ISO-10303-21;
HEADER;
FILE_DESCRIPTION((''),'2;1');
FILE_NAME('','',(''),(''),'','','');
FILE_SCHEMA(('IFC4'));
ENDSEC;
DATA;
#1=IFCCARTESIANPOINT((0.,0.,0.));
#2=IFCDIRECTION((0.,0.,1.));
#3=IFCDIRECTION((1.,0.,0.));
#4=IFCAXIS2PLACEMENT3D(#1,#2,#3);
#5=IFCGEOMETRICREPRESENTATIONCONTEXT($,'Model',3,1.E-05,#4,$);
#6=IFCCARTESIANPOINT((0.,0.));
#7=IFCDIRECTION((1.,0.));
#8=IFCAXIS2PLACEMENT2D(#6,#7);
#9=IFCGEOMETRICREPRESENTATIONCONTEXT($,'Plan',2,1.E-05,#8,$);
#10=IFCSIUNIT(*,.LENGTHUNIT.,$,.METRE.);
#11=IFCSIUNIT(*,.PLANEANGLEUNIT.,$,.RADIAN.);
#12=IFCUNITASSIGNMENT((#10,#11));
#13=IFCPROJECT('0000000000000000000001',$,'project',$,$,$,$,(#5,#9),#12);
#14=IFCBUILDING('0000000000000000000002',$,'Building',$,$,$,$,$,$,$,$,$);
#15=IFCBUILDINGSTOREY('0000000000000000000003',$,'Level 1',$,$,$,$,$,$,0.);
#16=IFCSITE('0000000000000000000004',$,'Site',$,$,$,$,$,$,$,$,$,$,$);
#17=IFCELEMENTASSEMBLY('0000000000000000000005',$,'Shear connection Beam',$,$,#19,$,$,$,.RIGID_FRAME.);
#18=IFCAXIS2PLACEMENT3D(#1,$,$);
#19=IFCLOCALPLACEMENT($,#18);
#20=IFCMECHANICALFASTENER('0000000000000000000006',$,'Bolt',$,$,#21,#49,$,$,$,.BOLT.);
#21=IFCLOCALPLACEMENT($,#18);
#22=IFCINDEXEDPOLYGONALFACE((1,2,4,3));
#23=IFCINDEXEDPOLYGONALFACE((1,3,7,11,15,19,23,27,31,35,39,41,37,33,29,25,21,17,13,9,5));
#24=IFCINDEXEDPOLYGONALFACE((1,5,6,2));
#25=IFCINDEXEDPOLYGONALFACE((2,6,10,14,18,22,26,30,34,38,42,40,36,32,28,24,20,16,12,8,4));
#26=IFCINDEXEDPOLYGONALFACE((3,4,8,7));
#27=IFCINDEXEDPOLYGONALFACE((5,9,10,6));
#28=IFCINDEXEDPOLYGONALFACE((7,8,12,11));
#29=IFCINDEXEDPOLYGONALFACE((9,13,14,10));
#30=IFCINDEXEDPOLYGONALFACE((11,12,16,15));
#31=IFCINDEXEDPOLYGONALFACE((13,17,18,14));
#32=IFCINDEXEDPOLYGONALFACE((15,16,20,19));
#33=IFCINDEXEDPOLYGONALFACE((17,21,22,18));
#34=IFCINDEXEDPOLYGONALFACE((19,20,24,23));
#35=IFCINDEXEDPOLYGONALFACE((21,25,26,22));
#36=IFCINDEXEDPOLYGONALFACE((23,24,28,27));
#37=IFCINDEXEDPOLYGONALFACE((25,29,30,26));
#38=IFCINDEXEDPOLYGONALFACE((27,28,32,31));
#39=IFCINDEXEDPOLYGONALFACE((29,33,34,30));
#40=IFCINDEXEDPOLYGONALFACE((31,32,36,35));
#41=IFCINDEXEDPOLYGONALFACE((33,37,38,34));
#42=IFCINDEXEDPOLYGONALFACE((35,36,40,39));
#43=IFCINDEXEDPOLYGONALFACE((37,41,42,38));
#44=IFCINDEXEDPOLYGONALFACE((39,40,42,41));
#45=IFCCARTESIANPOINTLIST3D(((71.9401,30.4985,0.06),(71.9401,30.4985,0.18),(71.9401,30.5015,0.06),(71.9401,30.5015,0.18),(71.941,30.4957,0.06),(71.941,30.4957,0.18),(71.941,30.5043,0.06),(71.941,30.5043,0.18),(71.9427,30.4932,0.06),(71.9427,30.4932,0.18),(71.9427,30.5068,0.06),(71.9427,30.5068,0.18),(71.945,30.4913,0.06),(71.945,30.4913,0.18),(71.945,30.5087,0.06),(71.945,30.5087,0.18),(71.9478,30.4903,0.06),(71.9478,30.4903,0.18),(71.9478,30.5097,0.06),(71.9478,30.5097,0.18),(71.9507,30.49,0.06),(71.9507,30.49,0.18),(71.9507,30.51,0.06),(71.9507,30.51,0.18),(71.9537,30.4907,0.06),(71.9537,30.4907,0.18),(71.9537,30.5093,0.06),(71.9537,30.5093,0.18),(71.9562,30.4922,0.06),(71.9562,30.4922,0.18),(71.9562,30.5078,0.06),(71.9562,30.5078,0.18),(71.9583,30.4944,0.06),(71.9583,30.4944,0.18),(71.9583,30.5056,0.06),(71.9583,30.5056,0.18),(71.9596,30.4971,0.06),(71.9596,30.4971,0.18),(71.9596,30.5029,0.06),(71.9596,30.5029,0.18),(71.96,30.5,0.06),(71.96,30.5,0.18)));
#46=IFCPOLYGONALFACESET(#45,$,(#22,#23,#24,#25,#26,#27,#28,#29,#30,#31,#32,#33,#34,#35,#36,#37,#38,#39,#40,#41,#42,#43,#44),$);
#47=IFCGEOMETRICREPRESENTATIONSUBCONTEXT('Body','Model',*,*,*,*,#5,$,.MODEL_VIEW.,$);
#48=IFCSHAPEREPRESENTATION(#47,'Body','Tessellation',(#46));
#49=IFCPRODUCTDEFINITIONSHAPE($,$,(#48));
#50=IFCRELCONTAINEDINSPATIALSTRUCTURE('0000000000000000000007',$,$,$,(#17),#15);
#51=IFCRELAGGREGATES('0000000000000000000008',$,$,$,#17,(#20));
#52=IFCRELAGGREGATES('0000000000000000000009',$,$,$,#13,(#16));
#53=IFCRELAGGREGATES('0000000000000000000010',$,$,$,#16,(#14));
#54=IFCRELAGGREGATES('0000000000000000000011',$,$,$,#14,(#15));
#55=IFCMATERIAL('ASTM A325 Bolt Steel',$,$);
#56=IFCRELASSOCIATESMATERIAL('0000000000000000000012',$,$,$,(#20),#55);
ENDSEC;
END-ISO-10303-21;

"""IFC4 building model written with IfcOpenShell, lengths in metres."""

from ifc_helpers import new_model, si_unit, frame, origin_with_axes, origin_2d, origin_2d_with_axis, place, context, subcontext, project, spatial, circle, extrude, material, element, aggregate, save


model = new_model("IFC4")

# Units and contexts
model_context = context("Model", 3, precision=1e-05, world=origin_with_axes())
plan_context = context("Plan", 2, precision=1e-05, world=origin_2d_with_axis())
body_context = subcontext(model_context, "Body", "Model", "MODEL_VIEW")
ifc_project = project(units=[si_unit("LENGTHUNIT", "METRE"), si_unit("PLANEANGLEUNIT", "RADIAN")], contexts=[model_context, plan_context])

# Site, building, storey
site = spatial("IfcSite", under=ifc_project, Name="Site")
building = spatial("IfcBuilding", under=site, Name="Building")
storey = spatial("IfcBuildingStorey", under=building, Name="Level 1", Elevation=0.0)

# Element assembly
assembly_1 = element("IfcElementAssembly", 1, inside=storey, Name="Shear connection Beam", PredefinedType="RIGID_FRAME")

# Shared definitions
ifc_material_1 = material(Name="ASTM A325 Bolt Steel")

# Mechanical fastener
mechanical_fastener_1_placement = place(None, frame((71.95, 30.5, 0.06), z_axis=(0.0, 0.0, 1.0), x_axis=(1.0, 0.0, 0.0)))
mechanical_fastener_1 = element("IfcMechanicalFastener", 2, at=mechanical_fastener_1_placement, material=ifc_material_1, Name="Bolt", PredefinedType="BOLT", context=body_context, shape_type="SweptSolid", body=[
    extrude(circle(Radius=0.01, at=origin_2d()), origin_with_axes(), (0.0, 0.0, 1.0), 0.12),
])
aggregate(assembly_1, [mechanical_fastener_1])

save(model, "model.ifc")
